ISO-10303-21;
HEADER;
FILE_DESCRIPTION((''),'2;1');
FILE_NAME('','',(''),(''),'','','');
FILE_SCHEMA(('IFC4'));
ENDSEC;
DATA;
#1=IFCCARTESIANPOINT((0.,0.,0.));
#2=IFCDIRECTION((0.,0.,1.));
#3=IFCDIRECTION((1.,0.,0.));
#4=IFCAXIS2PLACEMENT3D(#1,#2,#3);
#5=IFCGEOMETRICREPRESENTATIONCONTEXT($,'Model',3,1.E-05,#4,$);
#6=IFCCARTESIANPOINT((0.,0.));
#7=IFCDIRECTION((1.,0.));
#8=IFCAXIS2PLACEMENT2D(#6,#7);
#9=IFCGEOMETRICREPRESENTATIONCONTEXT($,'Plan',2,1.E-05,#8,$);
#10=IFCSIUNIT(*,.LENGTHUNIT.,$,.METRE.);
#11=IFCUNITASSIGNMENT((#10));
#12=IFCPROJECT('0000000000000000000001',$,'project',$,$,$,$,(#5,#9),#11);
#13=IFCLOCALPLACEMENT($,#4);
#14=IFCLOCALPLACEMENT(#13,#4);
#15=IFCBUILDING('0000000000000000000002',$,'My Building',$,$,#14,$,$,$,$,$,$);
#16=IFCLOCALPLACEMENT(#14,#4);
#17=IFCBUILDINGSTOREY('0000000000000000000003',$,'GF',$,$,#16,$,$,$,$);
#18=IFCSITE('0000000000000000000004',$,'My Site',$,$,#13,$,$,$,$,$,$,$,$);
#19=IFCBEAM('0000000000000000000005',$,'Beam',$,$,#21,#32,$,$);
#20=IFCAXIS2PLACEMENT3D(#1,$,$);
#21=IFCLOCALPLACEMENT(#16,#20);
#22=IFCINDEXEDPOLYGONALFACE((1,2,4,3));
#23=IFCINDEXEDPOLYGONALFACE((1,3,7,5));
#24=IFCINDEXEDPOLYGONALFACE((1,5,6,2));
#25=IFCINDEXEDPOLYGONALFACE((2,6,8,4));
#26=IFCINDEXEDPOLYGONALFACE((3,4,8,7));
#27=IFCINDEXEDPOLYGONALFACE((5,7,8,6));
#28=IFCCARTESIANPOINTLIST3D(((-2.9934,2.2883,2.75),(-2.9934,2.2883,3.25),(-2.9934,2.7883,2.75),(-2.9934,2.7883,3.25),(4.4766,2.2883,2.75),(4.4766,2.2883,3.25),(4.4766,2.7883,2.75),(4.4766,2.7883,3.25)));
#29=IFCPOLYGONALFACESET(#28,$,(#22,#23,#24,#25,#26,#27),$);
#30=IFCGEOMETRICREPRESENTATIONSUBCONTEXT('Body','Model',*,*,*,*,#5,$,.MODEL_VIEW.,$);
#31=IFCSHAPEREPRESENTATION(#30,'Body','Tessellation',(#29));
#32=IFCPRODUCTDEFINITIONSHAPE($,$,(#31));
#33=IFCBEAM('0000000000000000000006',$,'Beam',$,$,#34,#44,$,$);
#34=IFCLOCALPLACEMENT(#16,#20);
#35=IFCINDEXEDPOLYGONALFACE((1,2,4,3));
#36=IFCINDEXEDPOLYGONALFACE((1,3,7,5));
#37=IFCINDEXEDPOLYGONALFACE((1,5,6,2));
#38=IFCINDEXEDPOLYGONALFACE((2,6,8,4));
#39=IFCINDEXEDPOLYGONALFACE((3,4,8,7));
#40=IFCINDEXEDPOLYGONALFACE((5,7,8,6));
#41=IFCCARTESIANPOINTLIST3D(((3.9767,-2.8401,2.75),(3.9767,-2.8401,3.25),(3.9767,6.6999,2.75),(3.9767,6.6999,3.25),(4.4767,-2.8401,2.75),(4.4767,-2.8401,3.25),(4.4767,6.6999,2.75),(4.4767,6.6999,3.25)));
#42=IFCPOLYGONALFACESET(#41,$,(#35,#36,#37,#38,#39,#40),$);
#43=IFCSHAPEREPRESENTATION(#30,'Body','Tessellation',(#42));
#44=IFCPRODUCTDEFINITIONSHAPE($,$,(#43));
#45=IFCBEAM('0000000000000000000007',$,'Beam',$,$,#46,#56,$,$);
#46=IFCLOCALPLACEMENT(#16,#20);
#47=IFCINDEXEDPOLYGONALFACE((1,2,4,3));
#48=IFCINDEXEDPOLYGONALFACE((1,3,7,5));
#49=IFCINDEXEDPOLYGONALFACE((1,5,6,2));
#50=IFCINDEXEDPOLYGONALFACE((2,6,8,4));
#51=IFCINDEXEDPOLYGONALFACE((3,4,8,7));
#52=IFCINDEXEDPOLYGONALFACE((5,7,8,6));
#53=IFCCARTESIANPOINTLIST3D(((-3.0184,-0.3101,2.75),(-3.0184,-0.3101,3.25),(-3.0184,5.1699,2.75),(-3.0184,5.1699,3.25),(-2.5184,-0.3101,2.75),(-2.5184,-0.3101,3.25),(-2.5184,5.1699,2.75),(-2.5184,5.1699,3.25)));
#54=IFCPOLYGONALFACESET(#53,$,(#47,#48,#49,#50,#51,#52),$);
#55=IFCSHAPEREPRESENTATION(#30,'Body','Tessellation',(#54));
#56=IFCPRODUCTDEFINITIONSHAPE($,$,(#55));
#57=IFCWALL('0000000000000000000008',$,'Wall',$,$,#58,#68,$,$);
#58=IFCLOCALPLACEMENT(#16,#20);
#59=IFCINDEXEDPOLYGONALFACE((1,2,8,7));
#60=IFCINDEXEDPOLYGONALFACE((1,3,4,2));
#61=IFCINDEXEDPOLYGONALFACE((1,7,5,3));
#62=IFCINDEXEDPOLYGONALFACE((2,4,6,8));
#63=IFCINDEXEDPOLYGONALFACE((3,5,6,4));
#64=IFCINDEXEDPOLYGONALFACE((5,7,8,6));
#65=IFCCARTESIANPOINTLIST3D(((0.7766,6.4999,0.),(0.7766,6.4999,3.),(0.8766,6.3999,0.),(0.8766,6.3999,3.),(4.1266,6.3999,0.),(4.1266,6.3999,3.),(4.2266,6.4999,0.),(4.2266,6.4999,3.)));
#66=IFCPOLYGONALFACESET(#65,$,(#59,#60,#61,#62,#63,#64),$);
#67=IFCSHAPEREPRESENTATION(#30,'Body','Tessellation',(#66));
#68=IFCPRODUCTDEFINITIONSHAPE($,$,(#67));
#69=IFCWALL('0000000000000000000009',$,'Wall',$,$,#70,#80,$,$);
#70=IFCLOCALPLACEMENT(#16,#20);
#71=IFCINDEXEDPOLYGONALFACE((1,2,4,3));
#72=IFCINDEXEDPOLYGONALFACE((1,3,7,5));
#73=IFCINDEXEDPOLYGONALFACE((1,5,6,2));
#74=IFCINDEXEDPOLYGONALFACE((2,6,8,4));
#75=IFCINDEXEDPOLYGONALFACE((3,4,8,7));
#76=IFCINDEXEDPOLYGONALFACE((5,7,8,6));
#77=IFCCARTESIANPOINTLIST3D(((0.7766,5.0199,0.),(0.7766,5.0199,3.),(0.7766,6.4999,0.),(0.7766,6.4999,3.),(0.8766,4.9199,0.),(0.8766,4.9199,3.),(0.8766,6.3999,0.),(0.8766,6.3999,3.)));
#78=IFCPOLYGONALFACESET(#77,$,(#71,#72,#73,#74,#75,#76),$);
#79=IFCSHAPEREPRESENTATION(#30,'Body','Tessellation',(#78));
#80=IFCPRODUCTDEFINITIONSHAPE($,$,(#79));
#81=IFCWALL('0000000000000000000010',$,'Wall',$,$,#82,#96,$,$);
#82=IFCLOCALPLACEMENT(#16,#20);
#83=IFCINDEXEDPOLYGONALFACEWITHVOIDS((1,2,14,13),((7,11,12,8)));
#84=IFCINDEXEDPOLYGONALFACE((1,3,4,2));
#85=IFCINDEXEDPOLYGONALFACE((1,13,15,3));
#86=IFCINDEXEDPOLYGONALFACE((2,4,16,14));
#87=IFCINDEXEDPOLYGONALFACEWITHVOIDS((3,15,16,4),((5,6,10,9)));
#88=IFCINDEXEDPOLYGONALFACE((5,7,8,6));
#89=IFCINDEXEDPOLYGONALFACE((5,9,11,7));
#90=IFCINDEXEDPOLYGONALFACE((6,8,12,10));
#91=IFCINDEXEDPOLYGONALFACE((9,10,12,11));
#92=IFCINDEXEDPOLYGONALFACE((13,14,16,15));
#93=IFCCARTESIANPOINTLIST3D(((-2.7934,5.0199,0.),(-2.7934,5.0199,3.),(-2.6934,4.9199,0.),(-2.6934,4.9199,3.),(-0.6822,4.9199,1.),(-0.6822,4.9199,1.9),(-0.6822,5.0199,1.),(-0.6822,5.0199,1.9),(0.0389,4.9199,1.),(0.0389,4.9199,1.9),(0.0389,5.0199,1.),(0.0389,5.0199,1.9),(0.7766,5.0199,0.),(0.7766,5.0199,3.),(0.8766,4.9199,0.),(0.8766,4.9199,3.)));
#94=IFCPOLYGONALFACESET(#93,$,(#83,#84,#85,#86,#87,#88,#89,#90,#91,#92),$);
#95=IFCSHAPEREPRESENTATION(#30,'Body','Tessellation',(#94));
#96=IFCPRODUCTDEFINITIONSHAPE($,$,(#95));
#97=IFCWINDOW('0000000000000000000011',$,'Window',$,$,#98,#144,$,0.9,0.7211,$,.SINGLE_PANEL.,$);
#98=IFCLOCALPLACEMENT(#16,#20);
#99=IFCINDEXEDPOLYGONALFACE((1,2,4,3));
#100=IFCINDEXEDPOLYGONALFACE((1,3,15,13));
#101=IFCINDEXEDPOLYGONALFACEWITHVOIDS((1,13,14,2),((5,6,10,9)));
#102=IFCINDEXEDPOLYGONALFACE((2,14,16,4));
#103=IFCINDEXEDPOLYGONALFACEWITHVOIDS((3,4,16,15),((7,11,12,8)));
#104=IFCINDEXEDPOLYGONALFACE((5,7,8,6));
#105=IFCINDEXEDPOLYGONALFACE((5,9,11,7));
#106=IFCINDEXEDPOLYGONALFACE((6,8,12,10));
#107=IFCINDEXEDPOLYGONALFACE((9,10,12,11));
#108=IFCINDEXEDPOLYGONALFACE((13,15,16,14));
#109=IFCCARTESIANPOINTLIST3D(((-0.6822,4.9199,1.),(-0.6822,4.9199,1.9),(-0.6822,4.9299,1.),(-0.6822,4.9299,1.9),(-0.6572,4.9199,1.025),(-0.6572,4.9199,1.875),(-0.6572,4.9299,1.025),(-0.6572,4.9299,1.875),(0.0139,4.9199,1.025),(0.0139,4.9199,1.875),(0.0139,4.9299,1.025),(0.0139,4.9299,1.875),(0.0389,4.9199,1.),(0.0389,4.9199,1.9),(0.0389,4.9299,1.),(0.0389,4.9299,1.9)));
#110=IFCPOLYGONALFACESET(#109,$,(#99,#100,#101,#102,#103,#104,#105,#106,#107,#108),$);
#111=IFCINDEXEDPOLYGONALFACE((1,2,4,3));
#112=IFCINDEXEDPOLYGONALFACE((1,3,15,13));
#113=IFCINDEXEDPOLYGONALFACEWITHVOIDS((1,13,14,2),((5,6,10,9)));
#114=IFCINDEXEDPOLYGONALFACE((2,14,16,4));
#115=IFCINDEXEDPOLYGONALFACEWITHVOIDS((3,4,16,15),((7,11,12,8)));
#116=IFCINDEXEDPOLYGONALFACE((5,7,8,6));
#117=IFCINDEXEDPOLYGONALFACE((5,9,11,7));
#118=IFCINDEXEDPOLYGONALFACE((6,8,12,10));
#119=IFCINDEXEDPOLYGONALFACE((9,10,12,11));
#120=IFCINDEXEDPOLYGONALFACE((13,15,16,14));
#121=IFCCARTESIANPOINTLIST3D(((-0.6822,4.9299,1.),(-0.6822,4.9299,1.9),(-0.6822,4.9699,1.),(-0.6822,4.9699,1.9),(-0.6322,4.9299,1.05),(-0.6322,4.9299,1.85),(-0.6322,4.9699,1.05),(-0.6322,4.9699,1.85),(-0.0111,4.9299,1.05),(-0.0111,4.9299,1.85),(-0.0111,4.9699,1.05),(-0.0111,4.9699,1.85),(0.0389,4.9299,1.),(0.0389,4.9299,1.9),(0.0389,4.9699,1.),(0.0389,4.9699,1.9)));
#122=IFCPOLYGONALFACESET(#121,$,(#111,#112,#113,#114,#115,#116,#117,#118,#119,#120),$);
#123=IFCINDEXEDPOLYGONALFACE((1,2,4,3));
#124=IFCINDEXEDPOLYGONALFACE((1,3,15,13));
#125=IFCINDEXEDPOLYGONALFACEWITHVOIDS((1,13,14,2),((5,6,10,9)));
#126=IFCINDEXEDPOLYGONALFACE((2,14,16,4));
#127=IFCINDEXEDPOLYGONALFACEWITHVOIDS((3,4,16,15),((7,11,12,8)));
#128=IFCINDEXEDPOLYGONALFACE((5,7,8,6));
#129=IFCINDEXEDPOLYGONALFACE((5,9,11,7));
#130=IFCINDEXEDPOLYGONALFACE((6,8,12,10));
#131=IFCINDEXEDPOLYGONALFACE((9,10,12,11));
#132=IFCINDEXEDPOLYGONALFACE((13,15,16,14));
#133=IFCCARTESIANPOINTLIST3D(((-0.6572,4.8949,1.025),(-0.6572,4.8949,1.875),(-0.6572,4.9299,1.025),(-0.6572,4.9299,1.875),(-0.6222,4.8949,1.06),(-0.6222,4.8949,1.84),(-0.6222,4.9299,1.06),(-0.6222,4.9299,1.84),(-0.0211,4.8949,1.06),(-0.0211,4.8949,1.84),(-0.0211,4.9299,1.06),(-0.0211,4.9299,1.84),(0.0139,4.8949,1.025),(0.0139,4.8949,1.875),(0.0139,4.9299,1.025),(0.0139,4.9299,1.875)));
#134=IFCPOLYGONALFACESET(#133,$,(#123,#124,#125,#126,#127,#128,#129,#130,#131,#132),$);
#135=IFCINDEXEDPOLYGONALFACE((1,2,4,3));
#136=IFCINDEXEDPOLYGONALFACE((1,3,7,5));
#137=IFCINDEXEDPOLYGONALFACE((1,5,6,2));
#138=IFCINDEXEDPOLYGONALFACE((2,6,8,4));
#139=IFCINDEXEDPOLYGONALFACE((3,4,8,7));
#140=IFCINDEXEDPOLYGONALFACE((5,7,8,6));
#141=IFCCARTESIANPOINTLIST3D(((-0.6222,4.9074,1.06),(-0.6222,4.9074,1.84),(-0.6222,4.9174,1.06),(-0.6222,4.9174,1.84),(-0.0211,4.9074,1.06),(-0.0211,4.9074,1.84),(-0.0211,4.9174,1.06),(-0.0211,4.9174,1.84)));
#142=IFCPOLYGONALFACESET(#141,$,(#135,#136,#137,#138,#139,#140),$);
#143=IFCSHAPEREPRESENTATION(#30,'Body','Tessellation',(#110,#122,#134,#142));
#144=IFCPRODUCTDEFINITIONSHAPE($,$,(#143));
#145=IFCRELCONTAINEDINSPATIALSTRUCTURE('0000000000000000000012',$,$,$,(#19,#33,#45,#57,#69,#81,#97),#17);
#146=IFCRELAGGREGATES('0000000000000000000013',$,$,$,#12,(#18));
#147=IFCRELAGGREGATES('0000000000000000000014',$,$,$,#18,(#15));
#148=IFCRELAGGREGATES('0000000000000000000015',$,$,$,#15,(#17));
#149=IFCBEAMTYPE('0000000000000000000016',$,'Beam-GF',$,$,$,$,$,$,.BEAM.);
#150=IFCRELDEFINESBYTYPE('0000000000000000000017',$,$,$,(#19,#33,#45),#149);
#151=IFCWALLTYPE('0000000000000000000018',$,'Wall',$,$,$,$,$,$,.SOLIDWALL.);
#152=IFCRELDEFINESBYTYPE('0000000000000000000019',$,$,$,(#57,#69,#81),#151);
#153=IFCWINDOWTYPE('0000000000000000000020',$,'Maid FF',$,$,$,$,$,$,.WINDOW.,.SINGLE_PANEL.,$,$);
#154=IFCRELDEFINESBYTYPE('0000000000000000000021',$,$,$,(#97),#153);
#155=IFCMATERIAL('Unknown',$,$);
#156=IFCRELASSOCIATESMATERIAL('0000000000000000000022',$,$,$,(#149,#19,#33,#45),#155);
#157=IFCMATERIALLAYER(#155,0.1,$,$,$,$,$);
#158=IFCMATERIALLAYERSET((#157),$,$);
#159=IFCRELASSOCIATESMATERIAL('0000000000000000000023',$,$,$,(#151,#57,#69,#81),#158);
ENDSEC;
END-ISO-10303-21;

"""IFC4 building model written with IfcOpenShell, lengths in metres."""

from ifc_helpers import new_model, entity, si_unit, frame, origin_with_axes, origin_2d_with_axis, place, context, subcontext, project, spatial, line, indexed_curve, rectangle, outline, extrude, shape, source, transform, mapped, material, layer, layer_set, layer_usage, material_profile, profile_set, profile_usage, type_object, type_shapes, element, fill, save


model = new_model("IFC4")

# Units and contexts
model_context = context("Model", 3, precision=1e-05, world=origin_with_axes())
plan_context = context("Plan", 2, precision=1e-05, world=origin_2d_with_axis())
body_context_1 = subcontext(model_context, "Body", "Model", "MODEL_VIEW")
body_context_2 = subcontext(plan_context, "Body", "Plan", "PLAN_VIEW")
ifc_project = project(units=[si_unit("LENGTHUNIT", "METRE")], contexts=[model_context, plan_context])

# Site, building, storey
site_placement = place(None, origin_with_axes())
site = spatial("IfcSite", under=ifc_project, at=site_placement, Name="My Site")
building_placement = place(site_placement, origin_with_axes())
building = spatial("IfcBuilding", under=site, at=building_placement, Name="My Building")
storey_placement = place(building_placement, origin_with_axes())
storey = spatial("IfcBuildingStorey", under=building, at=storey_placement, Name="GF")

# Shared definitions
ifc_material_1 = material(Name="Unknown")

# Beams
ifc_material_profile_1 = material_profile(ifc_material_1, rectangle(XDim=0.5, YDim=0.5))
ifc_profile_set_1 = profile_set([ifc_material_profile_1])
beam_type = type_object("IfcBeamType", Name="Beam-GF", PredefinedType="BEAM", material=ifc_profile_set_1)
ifc_profile_usage_1 = profile_usage(ifc_profile_set_1, cardinal=5)
beam_1_placement = place(storey_placement, frame((4.4766, 2.5383, 3.0), z_axis=(-1.0, -0.000001, 0.000001), x_axis=(0.000001, -1.0, 0.0)))
element("IfcBeam", 1, at=beam_1_placement, inside=storey, type_object=beam_type, material=ifc_profile_usage_1, Name="Beam", context=body_context_1, shape_type="SweptSolid", body=[
    extrude(rectangle(XDim=0.5, YDim=0.5), origin_with_axes(), (0.0, 0.0, 1.0), 7.47),
])
ifc_profile_usage_2 = profile_usage(ifc_profile_set_1, cardinal=5)
beam_2_placement = place(storey_placement, frame((4.2267, 6.6999, 3.0), z_axis=(0.0, -1.0, 0.0), x_axis=(1.0, 0.0, 0.0)))
element("IfcBeam", 2, at=beam_2_placement, inside=storey, type_object=beam_type, material=ifc_profile_usage_2, Name="Beam", context=body_context_1, shape_type="SweptSolid", body=[
    extrude(rectangle(XDim=0.5, YDim=0.5), origin_with_axes(), (0.0, 0.0, 1.0), 9.54),
])
ifc_profile_usage_3 = profile_usage(ifc_profile_set_1, cardinal=5)
beam_3_placement = place(storey_placement, frame((-2.7684, 5.1699, 3.0), z_axis=(0.0, -1.0, 0.0), x_axis=(1.0, 0.0, 0.0)))
element("IfcBeam", 3, at=beam_3_placement, inside=storey, type_object=beam_type, material=ifc_profile_usage_3, Name="Beam", context=body_context_1, shape_type="SweptSolid", body=[
    extrude(rectangle(XDim=0.5, YDim=0.5), origin_with_axes(), (0.0, 0.0, 1.0), 5.48),
])

# Walls
ifc_layer_1 = layer(ifc_material_1, 0.1)
ifc_layer_set_1 = layer_set([ifc_layer_1])
ifc_layer_usage_1 = layer_usage(ifc_layer_set_1, "AXIS2", "POSITIVE", 0.0)
wall_type = type_object("IfcWallType", Name="Wall", PredefinedType="SOLIDWALL", material=ifc_layer_set_1)
wall_1_placement = place(storey_placement, frame((4.2266, 6.4999, 0.0), z_axis=(0.0, 0.0, 1.0), x_axis=(-1.0, 0.0, 0.0)))
element("IfcWall", 4, at=wall_1_placement, inside=storey, type_object=wall_type, material=ifc_layer_usage_1, Name="Wall", context=body_context_1, shape_type="SweptSolid", body=[
    extrude(outline(indexed_curve([(0.0, 0.0), (0.1, 0.1), (3.35, 0.1), (3.45, 0.0)], segments=[line(1, 2, 3, 4, 1)])), origin_with_axes(), (0.0, 0.0, 1.0), 3.0),
])
ifc_layer_usage_2 = layer_usage(ifc_layer_set_1, "AXIS2", "POSITIVE", 0.0)
wall_2_placement = place(storey_placement, frame((0.7766, 6.4999, 0.0), z_axis=(0.0, 0.0, 1.0), x_axis=(0.0, -1.0, 0.0)))
element("IfcWall", 5, at=wall_2_placement, inside=storey, type_object=wall_type, material=ifc_layer_usage_2, Name="Wall", context=body_context_1, shape_type="SweptSolid", body=[
    extrude(outline(indexed_curve([(0.0, 0.0), (0.1, 0.1), (1.58, 0.1), (1.48, 0.0)], segments=[line(1, 2, 3, 4, 1)])), origin_with_axes(), (0.0, 0.0, 1.0), 3.0),
])

# Wall, opening, window
ifc_layer_usage_3 = layer_usage(ifc_layer_set_1, "AXIS2", "POSITIVE", 0.0)
wall_3_placement = place(storey_placement, frame((0.7766, 5.0199, 0.0), z_axis=(0.0, 0.0, 1.0), x_axis=(-1.0, 0.0, 0.0)))
wall_3 = element("IfcWall", 6, at=wall_3_placement, inside=storey, type_object=wall_type, material=ifc_layer_usage_3, Name="Wall", context=body_context_1, shape_type="SweptSolid", body=[
    extrude(outline(indexed_curve([(0.0, 0.0), (-0.1, 0.1), (3.47, 0.1), (3.57, 0.0)], segments=[line(1, 2, 3, 4, 1)])), origin_with_axes(), (0.0, 0.0, 1.0), 3.0),
])
shared_shape_1 = source(origin_with_axes(), body_context_1, "Body", "SweptSolid", [
    extrude(outline(indexed_curve([(0.0, 0.0), (0.7211, 0.0), (0.7211, 0.9), (0.0, 0.9)], segments=[line(1, 2, 3, 4, 1)])), frame((0.0, -0.6, 0.0), z_axis=(0.0, -1.0, 0.0), x_axis=(1.0, 0.0, 0.0)), (0.0, 0.0, -1.0), 1.2),
])
opening_1_placement = place(wall_3_placement, frame((0.7377, 0.0, 1.0), z_axis=(0.0, 0.0, 1.0), x_axis=(1.0, 0.0, 0.0)))
opening_1 = element("IfcOpeningElement", 7, at=opening_1_placement, cuts=wall_3, PredefinedType="OPENING", context=body_context_1, shape_type="MappedRepresentation", body=[
    mapped(shared_shape_1, transform((0.0, 0.0, 0.0), x_axis=(1.0, 0.0, 0.0), y_axis=(0.0, 1.0, 0.0), z_axis=(0.0, 0.0, 1.0), scale=1.0)),
])
window_type_1 = type_object("IfcWindowType", Name="Maid FF", PartitioningType="SINGLE_PANEL", PredefinedType="WINDOW")
shared_shape_2 = source(origin_with_axes(), body_context_1, "Body", "SweptSolid", [
    extrude(outline(indexed_curve([(0.0, 0.0), (0.7211, 0.0), (0.7211, 0.9), (0.0, 0.9)], segments=[line(1, 2, 3, 4, 1)]), holes=[indexed_curve([(0.025, 0.025), (0.6961, 0.025), (0.6961, 0.875), (0.025, 0.875)], segments=[line(1, 2, 3, 4, 1)])]), frame((0.0, 0.09, 0.0), z_axis=(0.0, -1.0, 0.0), x_axis=(1.0, 0.0, 0.0)), (0.0, 0.0, -1.0), 0.01),
    extrude(outline(indexed_curve([(0.0, 0.0), (0.7211, 0.0), (0.7211, 0.9), (0.0, 0.9)], segments=[line(1, 2, 3, 4, 1)]), holes=[indexed_curve([(0.05, 0.05), (0.6711, 0.05), (0.6711, 0.85), (0.05, 0.85)], segments=[line(1, 2, 3, 4, 1)])]), frame((0.0, 0.05, 0.0), z_axis=(0.0, -1.0, 0.0), x_axis=(1.0, 0.0, 0.0)), (0.0, 0.0, -1.0), 0.04),
    extrude(outline(indexed_curve([(0.0, 0.0), (0.6711, 0.0), (0.6711, 0.85), (0.0, 0.85)], segments=[line(1, 2, 3, 4, 1)]), holes=[indexed_curve([(0.035, 0.035), (0.6361, 0.035), (0.6361, 0.815), (0.035, 0.815)], segments=[line(1, 2, 3, 4, 1)])]), frame((0.025, 0.09, 0.025), z_axis=(0.0, -1.0, 0.0), x_axis=(1.0, 0.0, 0.0)), (0.0, 0.0, -1.0), 0.035),
    extrude(outline(indexed_curve([(0.035, 0.035), (0.6361, 0.035), (0.6361, 0.815), (0.035, 0.815)], segments=[line(1, 2, 3, 4, 1)])), frame((0.025, 0.1025, 0.025), z_axis=(0.0, -1.0, 0.0), x_axis=(1.0, 0.0, 0.0)), (0.0, 0.0, -1.0), 0.01),
])
shared_shape_3 = source(origin_with_axes(), body_context_2, "Body", "Curve2D", [
    entity("IfcIndexedPolyCurve", entity("IfcCartesianPointList2D", [[0.05, 0.05], [0.6711, 0.05]])),
    entity("IfcIndexedPolyCurve", entity("IfcCartesianPointList2D", [[0.0, 0.1], [0.025, 0.1], [0.025, 0.09], [0.05, 0.09], [0.05, 0.05], [0.0, 0.05]]), [entity("IfcLineIndex", [1, 2, 3, 4, 5, 6, 1])]),
    entity("IfcIndexedPolyCurve", entity("IfcCartesianPointList2D", [[0.7211, 0.1], [0.6961, 0.1], [0.6961, 0.09], [0.6711, 0.09], [0.6711, 0.05], [0.7211, 0.05]]), [entity("IfcLineIndex", [1, 2, 3, 4, 5, 6, 1])]),
    entity("IfcIndexedPolyCurve", entity("IfcCartesianPointList2D", [[0.025, 0.09], [0.06, 0.09], [0.06, 0.125], [0.025, 0.125]]), [entity("IfcLineIndex", [1, 2, 3, 4, 1])]),
    entity("IfcIndexedPolyCurve", entity("IfcCartesianPointList2D", [[0.6961, 0.09], [0.6611, 0.09], [0.6611, 0.125], [0.6961, 0.125]]), [entity("IfcLineIndex", [1, 2, 3, 4, 1])]),
    entity("IfcIndexedPolyCurve", entity("IfcCartesianPointList2D", [[0.06, 0.09], [0.6611, 0.09]])),
    entity("IfcIndexedPolyCurve", entity("IfcCartesianPointList2D", [[0.06, 0.125], [0.6611, 0.125]])),
    entity("IfcIndexedPolyCurve", entity("IfcCartesianPointList2D", [[0.06, 0.1075], [0.6611, 0.1075]])),
])
type_shapes(window_type_1, [shared_shape_2, shared_shape_3])
window_1_placement = place(opening_1_placement, frame((0.0, 0.0, 0.0), z_axis=(0.0, 0.0, 1.0), x_axis=(1.0, 0.0, 0.0)))
window_1 = element("IfcWindow", 8, at=window_1_placement, inside=storey, type_object=window_type_1, Name="Window", OverallHeight=0.9, OverallWidth=0.7211, PartitioningType="SINGLE_PANEL", shapes=[
    shape(body_context_1, "Body", "MappedRepresentation", [mapped(shared_shape_2, transform((0.0, 0.0, 0.0), x_axis=(1.0, 0.0, 0.0), y_axis=(0.0, 1.0, 0.0), z_axis=(0.0, 0.0, 1.0), scale=1.0))]),
    shape(body_context_2, "Body", "MappedRepresentation", [mapped(shared_shape_3, transform((0.0, 0.0, 0.0), x_axis=(1.0, 0.0, 0.0), y_axis=(0.0, 1.0, 0.0), z_axis=(0.0, 0.0, 1.0), scale=1.0))]),
])
fill(opening_1, window_1)

save(model, "model.ifc")
